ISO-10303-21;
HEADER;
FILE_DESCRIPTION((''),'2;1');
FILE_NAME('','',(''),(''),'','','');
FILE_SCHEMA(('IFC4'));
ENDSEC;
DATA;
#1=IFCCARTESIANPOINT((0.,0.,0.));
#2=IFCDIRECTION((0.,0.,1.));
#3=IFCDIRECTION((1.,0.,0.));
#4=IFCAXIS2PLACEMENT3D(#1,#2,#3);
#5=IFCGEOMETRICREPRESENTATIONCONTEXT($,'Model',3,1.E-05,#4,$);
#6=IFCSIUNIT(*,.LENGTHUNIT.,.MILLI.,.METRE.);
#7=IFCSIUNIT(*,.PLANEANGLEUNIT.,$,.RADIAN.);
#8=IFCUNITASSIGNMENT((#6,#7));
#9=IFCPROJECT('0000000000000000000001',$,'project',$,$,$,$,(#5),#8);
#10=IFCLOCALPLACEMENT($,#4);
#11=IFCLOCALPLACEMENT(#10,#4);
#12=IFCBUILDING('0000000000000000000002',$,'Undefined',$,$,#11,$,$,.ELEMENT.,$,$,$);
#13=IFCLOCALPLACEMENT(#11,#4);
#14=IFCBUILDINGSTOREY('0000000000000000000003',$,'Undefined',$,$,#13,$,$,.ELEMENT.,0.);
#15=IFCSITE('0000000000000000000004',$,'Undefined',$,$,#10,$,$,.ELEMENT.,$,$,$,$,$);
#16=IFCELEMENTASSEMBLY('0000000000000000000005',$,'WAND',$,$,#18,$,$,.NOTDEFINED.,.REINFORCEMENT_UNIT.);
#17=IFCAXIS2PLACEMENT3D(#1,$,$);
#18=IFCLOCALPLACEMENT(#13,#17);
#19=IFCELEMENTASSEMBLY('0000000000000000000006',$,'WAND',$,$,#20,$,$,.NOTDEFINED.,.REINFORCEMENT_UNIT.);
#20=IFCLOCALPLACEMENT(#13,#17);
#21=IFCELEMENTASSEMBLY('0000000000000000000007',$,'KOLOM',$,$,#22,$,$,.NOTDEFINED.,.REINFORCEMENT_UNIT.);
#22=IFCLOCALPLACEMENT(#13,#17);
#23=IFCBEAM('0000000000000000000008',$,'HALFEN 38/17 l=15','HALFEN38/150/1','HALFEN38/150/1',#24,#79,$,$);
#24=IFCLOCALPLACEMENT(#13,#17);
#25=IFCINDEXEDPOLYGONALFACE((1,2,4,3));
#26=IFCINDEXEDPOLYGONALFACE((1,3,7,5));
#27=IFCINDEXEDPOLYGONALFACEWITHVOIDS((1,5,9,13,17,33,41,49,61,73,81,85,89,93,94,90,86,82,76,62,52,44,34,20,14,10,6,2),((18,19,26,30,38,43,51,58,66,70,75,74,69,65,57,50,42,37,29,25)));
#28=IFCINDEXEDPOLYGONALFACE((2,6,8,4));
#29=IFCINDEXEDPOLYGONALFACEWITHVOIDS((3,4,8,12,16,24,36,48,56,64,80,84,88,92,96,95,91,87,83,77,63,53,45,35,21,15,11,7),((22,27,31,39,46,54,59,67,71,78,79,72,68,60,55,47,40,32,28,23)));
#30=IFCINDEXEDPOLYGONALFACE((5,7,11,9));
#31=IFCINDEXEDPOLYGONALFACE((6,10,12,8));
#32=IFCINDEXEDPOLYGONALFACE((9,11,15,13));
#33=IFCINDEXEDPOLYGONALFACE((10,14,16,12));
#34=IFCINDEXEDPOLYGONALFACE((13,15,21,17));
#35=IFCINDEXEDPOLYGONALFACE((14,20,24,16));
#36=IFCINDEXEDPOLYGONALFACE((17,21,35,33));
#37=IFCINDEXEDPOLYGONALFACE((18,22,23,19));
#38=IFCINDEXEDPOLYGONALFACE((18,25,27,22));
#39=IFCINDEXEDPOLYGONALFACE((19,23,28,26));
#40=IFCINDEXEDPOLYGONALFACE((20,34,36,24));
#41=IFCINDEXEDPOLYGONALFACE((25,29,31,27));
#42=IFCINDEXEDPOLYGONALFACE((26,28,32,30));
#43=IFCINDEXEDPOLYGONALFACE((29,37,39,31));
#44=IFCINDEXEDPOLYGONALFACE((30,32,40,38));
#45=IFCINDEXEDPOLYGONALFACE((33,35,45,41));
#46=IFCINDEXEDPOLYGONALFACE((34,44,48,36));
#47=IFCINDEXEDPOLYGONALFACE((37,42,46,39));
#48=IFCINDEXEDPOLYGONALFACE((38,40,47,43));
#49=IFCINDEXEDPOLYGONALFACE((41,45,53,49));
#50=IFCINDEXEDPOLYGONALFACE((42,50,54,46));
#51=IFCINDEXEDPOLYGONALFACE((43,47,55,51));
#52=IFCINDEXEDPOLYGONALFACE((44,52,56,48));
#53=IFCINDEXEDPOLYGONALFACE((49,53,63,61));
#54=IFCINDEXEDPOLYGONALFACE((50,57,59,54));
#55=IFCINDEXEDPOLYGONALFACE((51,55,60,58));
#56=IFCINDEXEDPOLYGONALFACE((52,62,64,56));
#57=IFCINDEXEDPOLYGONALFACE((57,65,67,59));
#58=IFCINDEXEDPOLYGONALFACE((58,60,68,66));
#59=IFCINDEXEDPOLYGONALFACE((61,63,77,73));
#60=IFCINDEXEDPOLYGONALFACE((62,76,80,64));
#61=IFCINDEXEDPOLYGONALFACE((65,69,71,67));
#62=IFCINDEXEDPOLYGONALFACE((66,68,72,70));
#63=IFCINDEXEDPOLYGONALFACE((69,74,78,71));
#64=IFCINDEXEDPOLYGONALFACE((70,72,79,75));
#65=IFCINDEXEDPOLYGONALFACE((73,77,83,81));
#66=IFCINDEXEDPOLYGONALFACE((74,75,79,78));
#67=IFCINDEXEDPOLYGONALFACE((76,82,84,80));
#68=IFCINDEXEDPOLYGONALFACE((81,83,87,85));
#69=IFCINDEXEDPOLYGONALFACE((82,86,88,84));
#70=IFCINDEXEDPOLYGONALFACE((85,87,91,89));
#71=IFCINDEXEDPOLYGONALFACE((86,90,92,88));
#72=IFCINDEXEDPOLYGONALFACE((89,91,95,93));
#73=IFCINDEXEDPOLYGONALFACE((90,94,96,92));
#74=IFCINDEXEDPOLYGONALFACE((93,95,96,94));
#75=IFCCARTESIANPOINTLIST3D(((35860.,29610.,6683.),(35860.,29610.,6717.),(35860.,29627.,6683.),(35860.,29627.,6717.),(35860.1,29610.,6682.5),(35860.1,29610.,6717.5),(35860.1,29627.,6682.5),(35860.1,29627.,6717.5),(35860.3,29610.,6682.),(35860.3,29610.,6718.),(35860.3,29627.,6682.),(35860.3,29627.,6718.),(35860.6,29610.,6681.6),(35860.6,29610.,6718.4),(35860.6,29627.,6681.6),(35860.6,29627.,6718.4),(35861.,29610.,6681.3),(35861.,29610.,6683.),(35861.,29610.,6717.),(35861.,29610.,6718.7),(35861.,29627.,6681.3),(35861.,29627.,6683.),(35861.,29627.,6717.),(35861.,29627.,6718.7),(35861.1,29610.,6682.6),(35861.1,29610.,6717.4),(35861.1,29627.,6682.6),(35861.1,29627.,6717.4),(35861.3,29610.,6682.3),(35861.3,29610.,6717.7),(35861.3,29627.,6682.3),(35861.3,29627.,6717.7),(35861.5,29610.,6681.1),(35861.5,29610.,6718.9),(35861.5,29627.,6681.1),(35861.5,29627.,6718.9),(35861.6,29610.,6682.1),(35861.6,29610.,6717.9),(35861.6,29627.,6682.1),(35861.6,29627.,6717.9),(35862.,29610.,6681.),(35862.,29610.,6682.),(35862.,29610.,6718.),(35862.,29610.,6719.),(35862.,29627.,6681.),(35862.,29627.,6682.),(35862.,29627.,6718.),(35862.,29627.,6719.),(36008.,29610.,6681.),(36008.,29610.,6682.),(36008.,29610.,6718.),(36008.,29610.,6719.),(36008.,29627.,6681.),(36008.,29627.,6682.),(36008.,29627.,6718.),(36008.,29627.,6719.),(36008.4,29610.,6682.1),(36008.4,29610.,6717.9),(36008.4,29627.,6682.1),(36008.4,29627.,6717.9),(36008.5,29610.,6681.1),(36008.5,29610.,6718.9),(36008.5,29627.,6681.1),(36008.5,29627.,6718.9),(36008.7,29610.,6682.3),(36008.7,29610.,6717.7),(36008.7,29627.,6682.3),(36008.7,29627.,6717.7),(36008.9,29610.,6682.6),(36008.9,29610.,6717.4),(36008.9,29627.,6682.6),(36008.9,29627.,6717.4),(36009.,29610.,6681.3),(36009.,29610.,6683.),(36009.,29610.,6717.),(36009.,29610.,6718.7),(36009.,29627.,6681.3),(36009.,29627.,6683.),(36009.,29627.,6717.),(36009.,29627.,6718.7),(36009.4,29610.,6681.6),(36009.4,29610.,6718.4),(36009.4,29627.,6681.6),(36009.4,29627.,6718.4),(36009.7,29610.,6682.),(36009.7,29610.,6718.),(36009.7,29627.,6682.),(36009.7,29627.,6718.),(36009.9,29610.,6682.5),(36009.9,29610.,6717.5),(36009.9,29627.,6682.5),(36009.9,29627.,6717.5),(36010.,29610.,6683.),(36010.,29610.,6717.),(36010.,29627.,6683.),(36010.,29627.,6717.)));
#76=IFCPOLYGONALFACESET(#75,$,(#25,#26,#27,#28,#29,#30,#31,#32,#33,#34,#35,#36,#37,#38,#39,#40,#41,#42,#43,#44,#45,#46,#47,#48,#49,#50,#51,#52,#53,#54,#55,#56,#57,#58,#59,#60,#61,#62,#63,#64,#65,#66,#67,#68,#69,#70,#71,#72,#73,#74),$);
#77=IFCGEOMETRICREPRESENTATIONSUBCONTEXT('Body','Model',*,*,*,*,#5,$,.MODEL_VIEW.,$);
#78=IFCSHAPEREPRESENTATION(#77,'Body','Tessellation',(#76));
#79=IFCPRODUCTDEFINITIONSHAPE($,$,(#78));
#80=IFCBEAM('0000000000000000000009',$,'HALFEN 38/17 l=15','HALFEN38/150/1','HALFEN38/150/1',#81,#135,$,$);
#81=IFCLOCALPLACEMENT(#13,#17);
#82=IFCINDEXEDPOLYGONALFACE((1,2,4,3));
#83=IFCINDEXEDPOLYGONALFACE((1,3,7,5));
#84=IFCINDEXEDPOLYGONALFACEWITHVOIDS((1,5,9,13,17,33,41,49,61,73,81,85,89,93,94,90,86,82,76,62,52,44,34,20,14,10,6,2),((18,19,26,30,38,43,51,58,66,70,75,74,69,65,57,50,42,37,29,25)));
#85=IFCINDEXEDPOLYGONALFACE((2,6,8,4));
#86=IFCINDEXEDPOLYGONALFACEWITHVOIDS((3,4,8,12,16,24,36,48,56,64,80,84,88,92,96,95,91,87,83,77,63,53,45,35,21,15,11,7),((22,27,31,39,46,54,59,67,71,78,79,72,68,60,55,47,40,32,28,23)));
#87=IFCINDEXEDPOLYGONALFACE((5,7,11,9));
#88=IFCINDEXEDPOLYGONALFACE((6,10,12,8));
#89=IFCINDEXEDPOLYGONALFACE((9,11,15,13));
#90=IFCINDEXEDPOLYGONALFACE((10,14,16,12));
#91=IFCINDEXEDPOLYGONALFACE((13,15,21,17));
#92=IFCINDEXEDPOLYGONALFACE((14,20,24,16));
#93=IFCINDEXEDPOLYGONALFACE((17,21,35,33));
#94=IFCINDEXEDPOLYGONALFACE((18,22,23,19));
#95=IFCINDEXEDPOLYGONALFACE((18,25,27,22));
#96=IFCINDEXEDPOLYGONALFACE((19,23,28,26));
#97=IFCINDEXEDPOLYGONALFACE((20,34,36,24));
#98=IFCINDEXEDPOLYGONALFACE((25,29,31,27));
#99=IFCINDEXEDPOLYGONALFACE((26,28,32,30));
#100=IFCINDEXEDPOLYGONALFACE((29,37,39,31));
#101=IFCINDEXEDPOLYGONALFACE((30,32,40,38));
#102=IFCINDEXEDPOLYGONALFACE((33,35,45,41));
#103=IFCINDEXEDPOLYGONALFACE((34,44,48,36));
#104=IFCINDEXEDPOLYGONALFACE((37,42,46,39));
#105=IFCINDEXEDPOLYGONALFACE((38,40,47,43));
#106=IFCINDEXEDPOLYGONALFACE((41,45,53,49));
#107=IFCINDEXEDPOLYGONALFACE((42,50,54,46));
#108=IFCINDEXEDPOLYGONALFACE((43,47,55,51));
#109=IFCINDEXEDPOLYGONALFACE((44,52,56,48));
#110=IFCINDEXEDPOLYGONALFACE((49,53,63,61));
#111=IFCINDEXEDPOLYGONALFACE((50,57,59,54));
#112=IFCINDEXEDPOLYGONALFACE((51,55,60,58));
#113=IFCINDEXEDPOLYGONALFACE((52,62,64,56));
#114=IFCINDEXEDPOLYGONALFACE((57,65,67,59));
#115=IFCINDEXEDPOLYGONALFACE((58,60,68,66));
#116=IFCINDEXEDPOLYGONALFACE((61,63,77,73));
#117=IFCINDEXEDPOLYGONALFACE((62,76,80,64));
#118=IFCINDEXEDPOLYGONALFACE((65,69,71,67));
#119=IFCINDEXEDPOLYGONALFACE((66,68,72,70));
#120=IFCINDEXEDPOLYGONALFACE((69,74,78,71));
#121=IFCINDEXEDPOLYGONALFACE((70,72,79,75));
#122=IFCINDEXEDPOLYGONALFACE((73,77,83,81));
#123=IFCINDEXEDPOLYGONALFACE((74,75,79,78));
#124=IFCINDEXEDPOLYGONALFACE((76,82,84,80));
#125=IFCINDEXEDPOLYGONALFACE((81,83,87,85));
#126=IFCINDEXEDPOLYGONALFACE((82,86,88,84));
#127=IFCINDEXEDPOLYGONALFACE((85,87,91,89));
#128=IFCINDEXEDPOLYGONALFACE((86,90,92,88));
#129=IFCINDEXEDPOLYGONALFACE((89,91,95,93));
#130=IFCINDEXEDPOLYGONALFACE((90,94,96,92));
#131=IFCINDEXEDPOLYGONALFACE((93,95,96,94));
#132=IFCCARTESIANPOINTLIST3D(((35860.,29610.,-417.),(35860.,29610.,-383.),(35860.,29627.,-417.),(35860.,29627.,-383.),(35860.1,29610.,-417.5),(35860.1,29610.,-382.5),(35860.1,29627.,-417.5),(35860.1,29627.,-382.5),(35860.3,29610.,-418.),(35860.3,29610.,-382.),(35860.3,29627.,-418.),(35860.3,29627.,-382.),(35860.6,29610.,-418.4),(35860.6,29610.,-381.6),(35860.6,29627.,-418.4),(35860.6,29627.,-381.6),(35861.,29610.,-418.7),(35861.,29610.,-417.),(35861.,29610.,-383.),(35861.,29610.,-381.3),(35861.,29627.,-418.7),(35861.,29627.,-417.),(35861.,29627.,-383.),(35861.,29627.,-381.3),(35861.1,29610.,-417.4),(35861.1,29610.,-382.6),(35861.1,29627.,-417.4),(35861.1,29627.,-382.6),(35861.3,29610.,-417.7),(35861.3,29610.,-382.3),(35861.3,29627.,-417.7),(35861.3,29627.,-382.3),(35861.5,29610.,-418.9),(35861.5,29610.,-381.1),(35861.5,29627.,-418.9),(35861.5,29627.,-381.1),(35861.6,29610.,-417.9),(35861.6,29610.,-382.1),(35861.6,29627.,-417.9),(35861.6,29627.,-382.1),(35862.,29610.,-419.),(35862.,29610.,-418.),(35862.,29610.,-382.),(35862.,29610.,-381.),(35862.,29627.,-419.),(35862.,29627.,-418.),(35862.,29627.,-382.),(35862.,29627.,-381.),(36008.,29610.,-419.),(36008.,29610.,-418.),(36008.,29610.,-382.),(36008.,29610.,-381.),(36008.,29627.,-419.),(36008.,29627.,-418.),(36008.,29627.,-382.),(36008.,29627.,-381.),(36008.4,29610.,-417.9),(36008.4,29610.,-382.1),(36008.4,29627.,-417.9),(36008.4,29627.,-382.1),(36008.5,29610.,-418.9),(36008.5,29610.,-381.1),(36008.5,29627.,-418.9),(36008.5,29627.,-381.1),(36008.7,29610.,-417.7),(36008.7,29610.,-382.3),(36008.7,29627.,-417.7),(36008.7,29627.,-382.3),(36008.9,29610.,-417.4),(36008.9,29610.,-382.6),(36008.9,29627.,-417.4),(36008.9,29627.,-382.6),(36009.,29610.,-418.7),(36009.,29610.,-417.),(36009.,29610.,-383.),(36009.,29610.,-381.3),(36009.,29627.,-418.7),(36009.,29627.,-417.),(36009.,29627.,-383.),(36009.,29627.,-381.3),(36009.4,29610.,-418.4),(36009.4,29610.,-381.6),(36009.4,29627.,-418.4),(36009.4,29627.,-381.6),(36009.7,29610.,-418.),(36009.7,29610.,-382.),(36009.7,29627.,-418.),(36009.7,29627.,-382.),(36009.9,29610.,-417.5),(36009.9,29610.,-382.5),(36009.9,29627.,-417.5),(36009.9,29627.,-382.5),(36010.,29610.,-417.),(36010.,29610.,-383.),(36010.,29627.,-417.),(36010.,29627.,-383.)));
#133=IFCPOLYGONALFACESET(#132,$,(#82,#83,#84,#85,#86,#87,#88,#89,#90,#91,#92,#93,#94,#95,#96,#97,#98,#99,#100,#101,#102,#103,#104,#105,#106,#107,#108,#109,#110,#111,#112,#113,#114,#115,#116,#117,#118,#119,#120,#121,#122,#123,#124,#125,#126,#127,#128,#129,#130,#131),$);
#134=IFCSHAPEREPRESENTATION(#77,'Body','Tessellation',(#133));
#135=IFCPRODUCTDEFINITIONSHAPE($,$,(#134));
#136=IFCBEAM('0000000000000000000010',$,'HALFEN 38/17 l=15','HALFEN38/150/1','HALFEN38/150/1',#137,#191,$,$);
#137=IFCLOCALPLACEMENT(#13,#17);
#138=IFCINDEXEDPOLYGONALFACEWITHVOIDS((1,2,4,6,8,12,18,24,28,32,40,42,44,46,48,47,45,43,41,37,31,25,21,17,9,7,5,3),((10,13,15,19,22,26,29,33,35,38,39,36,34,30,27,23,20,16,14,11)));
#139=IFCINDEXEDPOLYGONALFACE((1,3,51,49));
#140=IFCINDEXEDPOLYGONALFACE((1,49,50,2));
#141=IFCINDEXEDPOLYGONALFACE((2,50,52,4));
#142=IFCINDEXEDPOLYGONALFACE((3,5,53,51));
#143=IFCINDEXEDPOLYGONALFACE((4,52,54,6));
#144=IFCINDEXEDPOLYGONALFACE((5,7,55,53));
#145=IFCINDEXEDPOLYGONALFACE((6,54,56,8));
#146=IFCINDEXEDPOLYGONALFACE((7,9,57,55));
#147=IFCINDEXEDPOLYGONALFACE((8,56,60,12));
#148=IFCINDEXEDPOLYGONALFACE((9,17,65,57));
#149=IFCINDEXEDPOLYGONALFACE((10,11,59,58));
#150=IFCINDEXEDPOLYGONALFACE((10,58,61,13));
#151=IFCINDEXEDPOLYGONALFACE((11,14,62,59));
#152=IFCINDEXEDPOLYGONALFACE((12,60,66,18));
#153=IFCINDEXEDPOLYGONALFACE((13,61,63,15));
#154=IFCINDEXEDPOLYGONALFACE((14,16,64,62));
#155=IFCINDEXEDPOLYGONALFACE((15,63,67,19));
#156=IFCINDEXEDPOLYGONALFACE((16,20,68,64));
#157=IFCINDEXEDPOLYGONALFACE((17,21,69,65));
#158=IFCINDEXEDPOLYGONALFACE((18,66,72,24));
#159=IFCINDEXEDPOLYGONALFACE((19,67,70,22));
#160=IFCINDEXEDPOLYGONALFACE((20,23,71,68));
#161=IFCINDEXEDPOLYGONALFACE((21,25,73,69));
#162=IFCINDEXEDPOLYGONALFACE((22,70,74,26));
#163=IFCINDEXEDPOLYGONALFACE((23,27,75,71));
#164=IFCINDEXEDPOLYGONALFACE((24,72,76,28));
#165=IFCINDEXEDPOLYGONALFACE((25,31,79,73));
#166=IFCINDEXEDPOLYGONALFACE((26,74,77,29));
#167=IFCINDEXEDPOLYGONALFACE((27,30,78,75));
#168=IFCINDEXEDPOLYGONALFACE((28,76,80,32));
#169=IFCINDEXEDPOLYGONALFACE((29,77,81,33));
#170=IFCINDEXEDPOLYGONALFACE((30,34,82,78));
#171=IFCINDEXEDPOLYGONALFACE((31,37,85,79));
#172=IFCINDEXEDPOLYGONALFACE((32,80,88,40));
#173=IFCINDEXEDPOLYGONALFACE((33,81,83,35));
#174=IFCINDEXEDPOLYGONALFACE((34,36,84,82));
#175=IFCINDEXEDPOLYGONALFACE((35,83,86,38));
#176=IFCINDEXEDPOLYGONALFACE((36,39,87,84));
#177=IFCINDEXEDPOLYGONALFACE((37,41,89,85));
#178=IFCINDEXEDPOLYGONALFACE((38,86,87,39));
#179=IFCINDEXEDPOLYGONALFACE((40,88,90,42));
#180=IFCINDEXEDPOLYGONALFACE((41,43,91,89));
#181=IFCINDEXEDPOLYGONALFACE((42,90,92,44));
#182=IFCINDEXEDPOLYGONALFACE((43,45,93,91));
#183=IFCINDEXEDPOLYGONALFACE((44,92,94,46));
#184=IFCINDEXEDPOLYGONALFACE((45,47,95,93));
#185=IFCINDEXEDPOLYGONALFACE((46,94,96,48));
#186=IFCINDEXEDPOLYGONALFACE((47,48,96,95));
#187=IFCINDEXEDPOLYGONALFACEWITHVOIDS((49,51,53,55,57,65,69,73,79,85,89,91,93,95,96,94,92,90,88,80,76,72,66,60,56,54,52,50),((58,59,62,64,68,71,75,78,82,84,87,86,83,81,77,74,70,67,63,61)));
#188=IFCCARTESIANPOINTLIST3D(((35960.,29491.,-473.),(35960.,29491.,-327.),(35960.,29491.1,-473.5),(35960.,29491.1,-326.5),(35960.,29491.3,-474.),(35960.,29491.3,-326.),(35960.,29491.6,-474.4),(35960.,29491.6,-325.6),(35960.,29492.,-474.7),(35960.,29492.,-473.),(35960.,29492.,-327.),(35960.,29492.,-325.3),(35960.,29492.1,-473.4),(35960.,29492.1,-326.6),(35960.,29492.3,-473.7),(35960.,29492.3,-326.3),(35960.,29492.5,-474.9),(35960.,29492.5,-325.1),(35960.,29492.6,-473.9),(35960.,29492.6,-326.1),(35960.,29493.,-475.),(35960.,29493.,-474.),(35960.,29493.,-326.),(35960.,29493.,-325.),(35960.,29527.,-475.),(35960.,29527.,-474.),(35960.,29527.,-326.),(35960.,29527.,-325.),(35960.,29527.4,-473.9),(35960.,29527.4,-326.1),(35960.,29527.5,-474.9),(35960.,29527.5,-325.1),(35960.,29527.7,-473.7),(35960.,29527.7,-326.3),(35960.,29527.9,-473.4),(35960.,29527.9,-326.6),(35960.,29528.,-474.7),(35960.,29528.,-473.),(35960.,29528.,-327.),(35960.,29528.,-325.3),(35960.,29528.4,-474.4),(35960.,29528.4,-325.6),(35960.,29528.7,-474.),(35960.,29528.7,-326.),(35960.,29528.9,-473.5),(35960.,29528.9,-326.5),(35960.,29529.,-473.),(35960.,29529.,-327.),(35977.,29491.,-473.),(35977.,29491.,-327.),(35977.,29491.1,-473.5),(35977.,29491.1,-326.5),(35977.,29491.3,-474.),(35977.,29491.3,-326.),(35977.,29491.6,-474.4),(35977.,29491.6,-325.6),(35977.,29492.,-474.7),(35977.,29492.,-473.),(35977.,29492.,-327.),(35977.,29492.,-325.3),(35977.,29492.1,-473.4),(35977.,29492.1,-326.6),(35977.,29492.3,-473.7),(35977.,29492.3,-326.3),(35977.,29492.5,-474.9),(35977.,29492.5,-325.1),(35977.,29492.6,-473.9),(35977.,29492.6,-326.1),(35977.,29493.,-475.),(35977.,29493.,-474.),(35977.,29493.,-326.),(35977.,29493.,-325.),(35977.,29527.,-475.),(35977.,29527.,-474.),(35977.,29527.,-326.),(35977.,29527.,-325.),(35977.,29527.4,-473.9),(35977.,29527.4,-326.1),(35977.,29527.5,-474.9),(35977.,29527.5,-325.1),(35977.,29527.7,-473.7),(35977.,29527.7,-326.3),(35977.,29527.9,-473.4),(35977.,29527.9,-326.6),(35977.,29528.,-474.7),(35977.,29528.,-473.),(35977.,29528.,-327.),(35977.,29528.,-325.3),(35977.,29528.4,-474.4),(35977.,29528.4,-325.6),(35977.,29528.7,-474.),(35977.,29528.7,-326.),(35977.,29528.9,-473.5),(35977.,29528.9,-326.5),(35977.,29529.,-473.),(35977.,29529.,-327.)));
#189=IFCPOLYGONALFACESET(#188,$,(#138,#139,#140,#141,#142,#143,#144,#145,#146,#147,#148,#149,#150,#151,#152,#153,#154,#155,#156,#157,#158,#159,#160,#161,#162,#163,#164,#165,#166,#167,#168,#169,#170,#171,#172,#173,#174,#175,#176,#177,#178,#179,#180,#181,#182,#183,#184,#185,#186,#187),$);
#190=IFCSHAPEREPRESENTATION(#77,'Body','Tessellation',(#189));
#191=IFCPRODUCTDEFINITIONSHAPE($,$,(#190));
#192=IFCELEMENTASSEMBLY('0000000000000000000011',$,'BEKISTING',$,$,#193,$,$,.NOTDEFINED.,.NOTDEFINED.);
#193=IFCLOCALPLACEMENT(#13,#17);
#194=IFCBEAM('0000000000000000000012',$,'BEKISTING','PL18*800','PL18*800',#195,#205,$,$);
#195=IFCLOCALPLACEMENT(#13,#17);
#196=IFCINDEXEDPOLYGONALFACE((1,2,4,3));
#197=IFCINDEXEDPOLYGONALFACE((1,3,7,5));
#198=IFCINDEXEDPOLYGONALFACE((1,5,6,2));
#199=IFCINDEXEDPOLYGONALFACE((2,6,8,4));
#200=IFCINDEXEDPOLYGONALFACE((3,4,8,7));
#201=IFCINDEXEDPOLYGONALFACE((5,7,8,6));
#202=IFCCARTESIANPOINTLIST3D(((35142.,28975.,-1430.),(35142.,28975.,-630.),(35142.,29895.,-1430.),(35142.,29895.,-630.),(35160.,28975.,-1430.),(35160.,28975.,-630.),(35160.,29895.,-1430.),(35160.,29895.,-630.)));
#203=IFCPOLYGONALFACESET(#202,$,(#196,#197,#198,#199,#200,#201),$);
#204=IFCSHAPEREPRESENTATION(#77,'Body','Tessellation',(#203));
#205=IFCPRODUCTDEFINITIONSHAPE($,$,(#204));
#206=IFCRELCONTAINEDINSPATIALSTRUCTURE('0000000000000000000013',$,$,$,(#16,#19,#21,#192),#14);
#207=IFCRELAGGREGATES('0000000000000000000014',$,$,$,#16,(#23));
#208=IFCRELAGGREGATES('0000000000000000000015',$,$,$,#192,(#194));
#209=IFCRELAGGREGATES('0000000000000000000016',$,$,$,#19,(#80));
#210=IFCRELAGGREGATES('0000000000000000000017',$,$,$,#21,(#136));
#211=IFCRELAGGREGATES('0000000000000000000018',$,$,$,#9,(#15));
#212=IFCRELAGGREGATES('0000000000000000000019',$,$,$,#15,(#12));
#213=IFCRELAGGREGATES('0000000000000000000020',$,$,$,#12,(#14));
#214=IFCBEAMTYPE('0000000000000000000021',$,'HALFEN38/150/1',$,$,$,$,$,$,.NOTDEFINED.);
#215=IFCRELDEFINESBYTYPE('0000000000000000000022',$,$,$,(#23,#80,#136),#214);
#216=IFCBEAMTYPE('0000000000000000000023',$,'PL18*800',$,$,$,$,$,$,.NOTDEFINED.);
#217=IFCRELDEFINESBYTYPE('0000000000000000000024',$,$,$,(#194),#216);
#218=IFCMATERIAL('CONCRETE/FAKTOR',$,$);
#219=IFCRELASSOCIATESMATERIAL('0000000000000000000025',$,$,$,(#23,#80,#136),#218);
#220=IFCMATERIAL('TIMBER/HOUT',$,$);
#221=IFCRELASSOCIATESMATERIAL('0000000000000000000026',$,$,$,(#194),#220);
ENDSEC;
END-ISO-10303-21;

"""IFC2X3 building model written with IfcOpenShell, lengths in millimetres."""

from ifc_helpers import new_model, si_unit, frame, frame_2d, origin_with_axes, place, context, subcontext, project, spatial, rectangle, hollow_rectangle, extrude, material, type_object, element, aggregate, save


model = new_model("IFC2X3")

# Units and contexts
model_context = context("Model", 3, precision=1e-05, world=origin_with_axes())
body_context = subcontext(model_context, "Body", "Model", "MODEL_VIEW")
ifc_project = project(units=[si_unit("LENGTHUNIT", "METRE", prefix="MILLI"), si_unit("PLANEANGLEUNIT", "RADIAN")], contexts=[model_context])

# Site, building, storey
site_placement = place(None, origin_with_axes())
site = spatial("IfcSite", under=ifc_project, at=site_placement, Name="Undefined", CompositionType="ELEMENT")
building_placement = place(site_placement, origin_with_axes())
building = spatial("IfcBuilding", under=site, at=building_placement, Name="Undefined", CompositionType="ELEMENT")
storey_placement = place(building_placement, origin_with_axes())
storey = spatial("IfcBuildingStorey", under=building, at=storey_placement, Name="Undefined", CompositionType="ELEMENT", Elevation=0.0)

# Element assembly
assembly_1_placement = place(storey_placement, origin_with_axes())
assembly_1 = element("IfcElementAssembly", 1, at=assembly_1_placement, inside=storey, Name="WAND", AssemblyPlace="NOTDEFINED", PredefinedType="REINFORCEMENT_UNIT")

# Element assembly
assembly_2_placement = place(storey_placement, origin_with_axes())
assembly_2 = element("IfcElementAssembly", 2, at=assembly_2_placement, inside=storey, Name="WAND", AssemblyPlace="NOTDEFINED", PredefinedType="REINFORCEMENT_UNIT")
ifc_material_1 = material(Name="CONCRETE/FAKTOR")

# Element assembly
assembly_3_placement = place(storey_placement, origin_with_axes())
assembly_3 = element("IfcElementAssembly", 3, at=assembly_3_placement, inside=storey, Name="KOLOM", AssemblyPlace="NOTDEFINED", PredefinedType="REINFORCEMENT_UNIT")

# Beams
beam_type_1 = type_object("IfcBeamType", Name="HALFEN38/150/1", PredefinedType="NOTDEFINED")
beam_1_placement = place(assembly_1_placement, frame((35935.0, 29610.0, 6700.0), z_axis=(0.0, 0.0, -1.0), x_axis=(0.0, 1.0, 0.0)))
beam_1 = element("IfcBeam", 4, at=beam_1_placement, type_object=beam_type_1, material=ifc_material_1, Name="HALFEN 38/17 l=15", Description="HALFEN38/150/1", ObjectType="HALFEN38/150/1", context=body_context, shape_type="SweptSolid", body=[
    extrude(hollow_rectangle(XDim=150.0, YDim=38.0, WallThickness=1.0, InnerFilletRadius=1.0, OuterFilletRadius=2.0, at=frame_2d((0.0, 0.0), x_axis=(1.0, 0.0))), frame((17.0, 0.0, 0.0), z_axis=(-1.0, 0.0, 0.0), x_axis=(0.0, -1.0, 0.0)), (0.0, 0.0, 1.0), 17.0),
])
beam_2_placement = place(assembly_2_placement, frame((35935.0, 29610.0, -400.0), z_axis=(0.0, 0.0, -1.0), x_axis=(0.0, 1.0, 0.0)))
beam_2 = element("IfcBeam", 5, at=beam_2_placement, type_object=beam_type_1, material=ifc_material_1, Name="HALFEN 38/17 l=15", Description="HALFEN38/150/1", ObjectType="HALFEN38/150/1", context=body_context, shape_type="SweptSolid", body=[
    extrude(hollow_rectangle(XDim=150.0, YDim=38.0, WallThickness=1.0, InnerFilletRadius=1.0, OuterFilletRadius=2.0, at=frame_2d((0.0, 0.0), x_axis=(1.0, 0.0))), frame((17.0, 0.0, 0.0), z_axis=(-1.0, 0.0, 0.0), x_axis=(0.0, -1.0, 0.0)), (0.0, 0.0, 1.0), 17.0),
])
beam_3_placement = place(assembly_3_placement, frame((35960.0, 29510.0, -400.0), z_axis=(0.0, -1.0, 0.0), x_axis=(1.0, 0.0, 0.0)))
beam_3 = element("IfcBeam", 6, at=beam_3_placement, type_object=beam_type_1, material=ifc_material_1, Name="HALFEN 38/17 l=15", Description="HALFEN38/150/1", ObjectType="HALFEN38/150/1", context=body_context, shape_type="SweptSolid", body=[
    extrude(hollow_rectangle(XDim=150.0, YDim=38.0, WallThickness=1.0, InnerFilletRadius=1.0, OuterFilletRadius=2.0, at=frame_2d((0.0, 0.0), x_axis=(1.0, 0.0))), frame((17.0, 0.0, 0.0), z_axis=(-1.0, 0.0, 0.0), x_axis=(0.0, -1.0, 0.0)), (0.0, 0.0, 1.0), 17.0),
])

# Element assembly, beam
assembly_4_placement = place(storey_placement, origin_with_axes())
assembly_4 = element("IfcElementAssembly", 7, at=assembly_4_placement, inside=storey, Name="BEKISTING", AssemblyPlace="NOTDEFINED", PredefinedType="NOTDEFINED")
ifc_material_2 = material(Name="TIMBER/HOUT")
beam_type_2 = type_object("IfcBeamType", Name="PL18*800", PredefinedType="NOTDEFINED")
beam_4_placement = place(assembly_4_placement, frame((35151.0, 28975.0, -1030.0), z_axis=(0.0, 0.0, -1.0), x_axis=(0.0, 1.0, 0.0)))
beam_4 = element("IfcBeam", 8, at=beam_4_placement, type_object=beam_type_2, material=ifc_material_2, Name="BEKISTING", Description="PL18*800", ObjectType="PL18*800", context=body_context, shape_type="SweptSolid", body=[
    extrude(rectangle(XDim=18.0, YDim=800.0, at=frame_2d((0.0, 0.0), x_axis=(1.0, 0.0))), frame((920.0, 0.0, 0.0), z_axis=(-1.0, 0.0, 0.0), x_axis=(0.0, -1.0, 0.0)), (0.0, 0.0, 1.0), 920.0),
])

aggregate(assembly_1, [beam_1])

aggregate(assembly_4, [beam_4])

aggregate(assembly_2, [beam_2])

aggregate(assembly_3, [beam_3])

save(model, "model.ifc")
